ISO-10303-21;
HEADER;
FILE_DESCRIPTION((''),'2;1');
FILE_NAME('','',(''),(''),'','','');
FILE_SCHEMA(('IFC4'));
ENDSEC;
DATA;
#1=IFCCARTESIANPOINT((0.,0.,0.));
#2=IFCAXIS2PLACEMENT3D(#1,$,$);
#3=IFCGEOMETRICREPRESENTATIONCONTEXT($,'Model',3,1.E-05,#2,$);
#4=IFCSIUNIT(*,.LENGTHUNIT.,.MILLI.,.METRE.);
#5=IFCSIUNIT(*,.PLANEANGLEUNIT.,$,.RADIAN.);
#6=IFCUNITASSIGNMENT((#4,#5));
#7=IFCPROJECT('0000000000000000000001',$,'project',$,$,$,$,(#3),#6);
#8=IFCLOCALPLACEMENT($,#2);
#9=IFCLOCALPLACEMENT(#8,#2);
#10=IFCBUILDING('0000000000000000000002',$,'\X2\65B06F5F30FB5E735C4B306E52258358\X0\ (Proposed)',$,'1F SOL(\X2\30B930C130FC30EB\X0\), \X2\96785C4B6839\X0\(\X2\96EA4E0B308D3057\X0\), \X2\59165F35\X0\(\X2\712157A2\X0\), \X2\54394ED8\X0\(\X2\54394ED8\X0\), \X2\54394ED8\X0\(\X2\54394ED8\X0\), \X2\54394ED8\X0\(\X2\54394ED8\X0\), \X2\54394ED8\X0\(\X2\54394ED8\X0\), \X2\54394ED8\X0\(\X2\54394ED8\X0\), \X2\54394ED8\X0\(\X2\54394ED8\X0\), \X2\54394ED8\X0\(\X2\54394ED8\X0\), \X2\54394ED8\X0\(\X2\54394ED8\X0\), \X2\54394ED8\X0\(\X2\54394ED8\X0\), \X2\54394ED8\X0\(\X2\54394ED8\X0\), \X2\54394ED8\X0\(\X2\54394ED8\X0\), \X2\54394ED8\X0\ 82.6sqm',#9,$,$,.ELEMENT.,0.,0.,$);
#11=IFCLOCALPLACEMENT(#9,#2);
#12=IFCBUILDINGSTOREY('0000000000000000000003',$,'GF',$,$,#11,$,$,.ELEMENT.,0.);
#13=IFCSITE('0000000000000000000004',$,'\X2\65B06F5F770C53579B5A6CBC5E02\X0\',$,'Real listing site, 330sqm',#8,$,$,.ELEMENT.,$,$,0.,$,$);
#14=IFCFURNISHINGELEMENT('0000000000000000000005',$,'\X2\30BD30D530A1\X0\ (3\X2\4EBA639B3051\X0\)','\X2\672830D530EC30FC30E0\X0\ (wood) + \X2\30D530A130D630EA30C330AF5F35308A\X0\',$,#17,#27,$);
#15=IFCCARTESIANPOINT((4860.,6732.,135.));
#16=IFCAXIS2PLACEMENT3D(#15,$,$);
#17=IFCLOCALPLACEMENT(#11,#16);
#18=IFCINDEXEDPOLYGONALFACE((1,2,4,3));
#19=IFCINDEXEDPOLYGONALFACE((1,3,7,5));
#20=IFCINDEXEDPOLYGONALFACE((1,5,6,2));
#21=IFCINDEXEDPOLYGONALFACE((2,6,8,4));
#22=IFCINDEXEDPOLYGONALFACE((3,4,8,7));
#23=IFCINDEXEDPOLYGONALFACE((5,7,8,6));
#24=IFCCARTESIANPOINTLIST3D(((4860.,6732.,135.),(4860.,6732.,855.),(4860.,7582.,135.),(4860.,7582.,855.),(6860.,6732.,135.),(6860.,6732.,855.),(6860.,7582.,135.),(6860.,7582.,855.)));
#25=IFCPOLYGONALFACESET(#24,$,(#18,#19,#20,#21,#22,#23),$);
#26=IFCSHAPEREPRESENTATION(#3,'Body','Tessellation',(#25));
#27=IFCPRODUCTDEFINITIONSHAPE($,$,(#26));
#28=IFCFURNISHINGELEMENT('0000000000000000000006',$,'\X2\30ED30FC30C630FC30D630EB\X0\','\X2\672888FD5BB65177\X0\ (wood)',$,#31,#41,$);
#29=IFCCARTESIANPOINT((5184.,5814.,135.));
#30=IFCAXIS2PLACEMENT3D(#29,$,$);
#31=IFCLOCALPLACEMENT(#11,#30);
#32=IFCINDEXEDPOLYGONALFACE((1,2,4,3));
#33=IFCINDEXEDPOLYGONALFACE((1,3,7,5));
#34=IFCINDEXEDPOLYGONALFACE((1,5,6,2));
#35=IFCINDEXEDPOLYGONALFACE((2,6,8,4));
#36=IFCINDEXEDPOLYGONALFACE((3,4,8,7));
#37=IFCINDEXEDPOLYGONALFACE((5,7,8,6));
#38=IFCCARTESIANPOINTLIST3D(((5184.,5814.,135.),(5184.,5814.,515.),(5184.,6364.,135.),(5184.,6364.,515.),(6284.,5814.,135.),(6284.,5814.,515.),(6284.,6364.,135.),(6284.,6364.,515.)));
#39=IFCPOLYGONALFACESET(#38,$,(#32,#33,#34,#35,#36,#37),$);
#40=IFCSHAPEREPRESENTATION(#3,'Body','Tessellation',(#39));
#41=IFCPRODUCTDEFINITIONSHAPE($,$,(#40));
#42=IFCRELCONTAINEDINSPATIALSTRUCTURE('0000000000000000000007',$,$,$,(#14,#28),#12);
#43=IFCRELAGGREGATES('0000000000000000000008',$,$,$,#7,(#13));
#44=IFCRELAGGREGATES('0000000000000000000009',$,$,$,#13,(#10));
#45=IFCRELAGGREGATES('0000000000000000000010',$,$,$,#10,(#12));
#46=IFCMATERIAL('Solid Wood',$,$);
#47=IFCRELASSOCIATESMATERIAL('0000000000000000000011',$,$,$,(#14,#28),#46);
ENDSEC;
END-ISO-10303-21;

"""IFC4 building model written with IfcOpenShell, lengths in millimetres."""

from ifc_helpers import new_model, si_unit, frame, frame_2d, origin, place, context, project, spatial, rectangle, extrude, material, element, save


model = new_model("IFC4")

# Units and contexts
model_context = context("Model", 3, precision=1e-05, world=origin())
ifc_project = project(units=[si_unit("LENGTHUNIT", "METRE", prefix="MILLI"), si_unit("PLANEANGLEUNIT", "RADIAN")], contexts=[model_context])

# Site, building, storey
site_placement = place(None, origin())
site = spatial("IfcSite", under=ifc_project, at=site_placement, Name="新潟県南魚沼市", ObjectType="Real listing site, 330sqm", CompositionType="ELEMENT", RefElevation=0.0)
building_placement = place(site_placement, origin())
building = spatial("IfcBuilding", under=site, at=building_placement, Name="新潟・平屋の別荘 (Proposed)", ObjectType="1F SOL(スチール), 陸屋根(雪下ろし), 外張(無垢), 吹付(吹付), 吹付(吹付), 吹付(吹付), 吹付(吹付), 吹付(吹付), 吹付(吹付), 吹付(吹付), 吹付(吹付), 吹付(吹付), 吹付(吹付), 吹付(吹付), 吹付 82.6sqm", CompositionType="ELEMENT", ElevationOfRefHeight=0.0, ElevationOfTerrain=0.0)
storey_placement = place(building_placement, origin())
storey = spatial("IfcBuildingStorey", under=building, at=storey_placement, Name="GF", CompositionType="ELEMENT", Elevation=0.0)

# Shared definitions
ifc_material_1 = material(Name="Solid Wood")

# Furnishing elements
furnishing_1_placement = place(storey_placement, frame((4860.0, 6732.0, 135.0)))
element("IfcFurnishingElement", 1, at=furnishing_1_placement, inside=storey, material=ifc_material_1, Name="ソファ (3人掛け)", Description="木フレーム (wood) + ファブリック張り", context=model_context, shape_type="SweptSolid", body=[
    extrude(rectangle(XDim=2000.0, YDim=850.0, at=frame_2d((1000.0, 425.0))), frame((4860.0, 6732.0, 135.0)), (0.0, 0.0, 1.0), 720.0),
])
furnishing_2_placement = place(storey_placement, frame((5184.0, 5814.0, 135.0)))
element("IfcFurnishingElement", 2, at=furnishing_2_placement, inside=storey, material=ifc_material_1, Name="ローテーブル", Description="木製家具 (wood)", context=model_context, shape_type="SweptSolid", body=[
    extrude(rectangle(XDim=1100.0, YDim=550.0, at=frame_2d((550.0, 275.0))), frame((5184.0, 5814.0, 135.0)), (0.0, 0.0, 1.0), 380.0),
])

save(model, "model.ifc")
